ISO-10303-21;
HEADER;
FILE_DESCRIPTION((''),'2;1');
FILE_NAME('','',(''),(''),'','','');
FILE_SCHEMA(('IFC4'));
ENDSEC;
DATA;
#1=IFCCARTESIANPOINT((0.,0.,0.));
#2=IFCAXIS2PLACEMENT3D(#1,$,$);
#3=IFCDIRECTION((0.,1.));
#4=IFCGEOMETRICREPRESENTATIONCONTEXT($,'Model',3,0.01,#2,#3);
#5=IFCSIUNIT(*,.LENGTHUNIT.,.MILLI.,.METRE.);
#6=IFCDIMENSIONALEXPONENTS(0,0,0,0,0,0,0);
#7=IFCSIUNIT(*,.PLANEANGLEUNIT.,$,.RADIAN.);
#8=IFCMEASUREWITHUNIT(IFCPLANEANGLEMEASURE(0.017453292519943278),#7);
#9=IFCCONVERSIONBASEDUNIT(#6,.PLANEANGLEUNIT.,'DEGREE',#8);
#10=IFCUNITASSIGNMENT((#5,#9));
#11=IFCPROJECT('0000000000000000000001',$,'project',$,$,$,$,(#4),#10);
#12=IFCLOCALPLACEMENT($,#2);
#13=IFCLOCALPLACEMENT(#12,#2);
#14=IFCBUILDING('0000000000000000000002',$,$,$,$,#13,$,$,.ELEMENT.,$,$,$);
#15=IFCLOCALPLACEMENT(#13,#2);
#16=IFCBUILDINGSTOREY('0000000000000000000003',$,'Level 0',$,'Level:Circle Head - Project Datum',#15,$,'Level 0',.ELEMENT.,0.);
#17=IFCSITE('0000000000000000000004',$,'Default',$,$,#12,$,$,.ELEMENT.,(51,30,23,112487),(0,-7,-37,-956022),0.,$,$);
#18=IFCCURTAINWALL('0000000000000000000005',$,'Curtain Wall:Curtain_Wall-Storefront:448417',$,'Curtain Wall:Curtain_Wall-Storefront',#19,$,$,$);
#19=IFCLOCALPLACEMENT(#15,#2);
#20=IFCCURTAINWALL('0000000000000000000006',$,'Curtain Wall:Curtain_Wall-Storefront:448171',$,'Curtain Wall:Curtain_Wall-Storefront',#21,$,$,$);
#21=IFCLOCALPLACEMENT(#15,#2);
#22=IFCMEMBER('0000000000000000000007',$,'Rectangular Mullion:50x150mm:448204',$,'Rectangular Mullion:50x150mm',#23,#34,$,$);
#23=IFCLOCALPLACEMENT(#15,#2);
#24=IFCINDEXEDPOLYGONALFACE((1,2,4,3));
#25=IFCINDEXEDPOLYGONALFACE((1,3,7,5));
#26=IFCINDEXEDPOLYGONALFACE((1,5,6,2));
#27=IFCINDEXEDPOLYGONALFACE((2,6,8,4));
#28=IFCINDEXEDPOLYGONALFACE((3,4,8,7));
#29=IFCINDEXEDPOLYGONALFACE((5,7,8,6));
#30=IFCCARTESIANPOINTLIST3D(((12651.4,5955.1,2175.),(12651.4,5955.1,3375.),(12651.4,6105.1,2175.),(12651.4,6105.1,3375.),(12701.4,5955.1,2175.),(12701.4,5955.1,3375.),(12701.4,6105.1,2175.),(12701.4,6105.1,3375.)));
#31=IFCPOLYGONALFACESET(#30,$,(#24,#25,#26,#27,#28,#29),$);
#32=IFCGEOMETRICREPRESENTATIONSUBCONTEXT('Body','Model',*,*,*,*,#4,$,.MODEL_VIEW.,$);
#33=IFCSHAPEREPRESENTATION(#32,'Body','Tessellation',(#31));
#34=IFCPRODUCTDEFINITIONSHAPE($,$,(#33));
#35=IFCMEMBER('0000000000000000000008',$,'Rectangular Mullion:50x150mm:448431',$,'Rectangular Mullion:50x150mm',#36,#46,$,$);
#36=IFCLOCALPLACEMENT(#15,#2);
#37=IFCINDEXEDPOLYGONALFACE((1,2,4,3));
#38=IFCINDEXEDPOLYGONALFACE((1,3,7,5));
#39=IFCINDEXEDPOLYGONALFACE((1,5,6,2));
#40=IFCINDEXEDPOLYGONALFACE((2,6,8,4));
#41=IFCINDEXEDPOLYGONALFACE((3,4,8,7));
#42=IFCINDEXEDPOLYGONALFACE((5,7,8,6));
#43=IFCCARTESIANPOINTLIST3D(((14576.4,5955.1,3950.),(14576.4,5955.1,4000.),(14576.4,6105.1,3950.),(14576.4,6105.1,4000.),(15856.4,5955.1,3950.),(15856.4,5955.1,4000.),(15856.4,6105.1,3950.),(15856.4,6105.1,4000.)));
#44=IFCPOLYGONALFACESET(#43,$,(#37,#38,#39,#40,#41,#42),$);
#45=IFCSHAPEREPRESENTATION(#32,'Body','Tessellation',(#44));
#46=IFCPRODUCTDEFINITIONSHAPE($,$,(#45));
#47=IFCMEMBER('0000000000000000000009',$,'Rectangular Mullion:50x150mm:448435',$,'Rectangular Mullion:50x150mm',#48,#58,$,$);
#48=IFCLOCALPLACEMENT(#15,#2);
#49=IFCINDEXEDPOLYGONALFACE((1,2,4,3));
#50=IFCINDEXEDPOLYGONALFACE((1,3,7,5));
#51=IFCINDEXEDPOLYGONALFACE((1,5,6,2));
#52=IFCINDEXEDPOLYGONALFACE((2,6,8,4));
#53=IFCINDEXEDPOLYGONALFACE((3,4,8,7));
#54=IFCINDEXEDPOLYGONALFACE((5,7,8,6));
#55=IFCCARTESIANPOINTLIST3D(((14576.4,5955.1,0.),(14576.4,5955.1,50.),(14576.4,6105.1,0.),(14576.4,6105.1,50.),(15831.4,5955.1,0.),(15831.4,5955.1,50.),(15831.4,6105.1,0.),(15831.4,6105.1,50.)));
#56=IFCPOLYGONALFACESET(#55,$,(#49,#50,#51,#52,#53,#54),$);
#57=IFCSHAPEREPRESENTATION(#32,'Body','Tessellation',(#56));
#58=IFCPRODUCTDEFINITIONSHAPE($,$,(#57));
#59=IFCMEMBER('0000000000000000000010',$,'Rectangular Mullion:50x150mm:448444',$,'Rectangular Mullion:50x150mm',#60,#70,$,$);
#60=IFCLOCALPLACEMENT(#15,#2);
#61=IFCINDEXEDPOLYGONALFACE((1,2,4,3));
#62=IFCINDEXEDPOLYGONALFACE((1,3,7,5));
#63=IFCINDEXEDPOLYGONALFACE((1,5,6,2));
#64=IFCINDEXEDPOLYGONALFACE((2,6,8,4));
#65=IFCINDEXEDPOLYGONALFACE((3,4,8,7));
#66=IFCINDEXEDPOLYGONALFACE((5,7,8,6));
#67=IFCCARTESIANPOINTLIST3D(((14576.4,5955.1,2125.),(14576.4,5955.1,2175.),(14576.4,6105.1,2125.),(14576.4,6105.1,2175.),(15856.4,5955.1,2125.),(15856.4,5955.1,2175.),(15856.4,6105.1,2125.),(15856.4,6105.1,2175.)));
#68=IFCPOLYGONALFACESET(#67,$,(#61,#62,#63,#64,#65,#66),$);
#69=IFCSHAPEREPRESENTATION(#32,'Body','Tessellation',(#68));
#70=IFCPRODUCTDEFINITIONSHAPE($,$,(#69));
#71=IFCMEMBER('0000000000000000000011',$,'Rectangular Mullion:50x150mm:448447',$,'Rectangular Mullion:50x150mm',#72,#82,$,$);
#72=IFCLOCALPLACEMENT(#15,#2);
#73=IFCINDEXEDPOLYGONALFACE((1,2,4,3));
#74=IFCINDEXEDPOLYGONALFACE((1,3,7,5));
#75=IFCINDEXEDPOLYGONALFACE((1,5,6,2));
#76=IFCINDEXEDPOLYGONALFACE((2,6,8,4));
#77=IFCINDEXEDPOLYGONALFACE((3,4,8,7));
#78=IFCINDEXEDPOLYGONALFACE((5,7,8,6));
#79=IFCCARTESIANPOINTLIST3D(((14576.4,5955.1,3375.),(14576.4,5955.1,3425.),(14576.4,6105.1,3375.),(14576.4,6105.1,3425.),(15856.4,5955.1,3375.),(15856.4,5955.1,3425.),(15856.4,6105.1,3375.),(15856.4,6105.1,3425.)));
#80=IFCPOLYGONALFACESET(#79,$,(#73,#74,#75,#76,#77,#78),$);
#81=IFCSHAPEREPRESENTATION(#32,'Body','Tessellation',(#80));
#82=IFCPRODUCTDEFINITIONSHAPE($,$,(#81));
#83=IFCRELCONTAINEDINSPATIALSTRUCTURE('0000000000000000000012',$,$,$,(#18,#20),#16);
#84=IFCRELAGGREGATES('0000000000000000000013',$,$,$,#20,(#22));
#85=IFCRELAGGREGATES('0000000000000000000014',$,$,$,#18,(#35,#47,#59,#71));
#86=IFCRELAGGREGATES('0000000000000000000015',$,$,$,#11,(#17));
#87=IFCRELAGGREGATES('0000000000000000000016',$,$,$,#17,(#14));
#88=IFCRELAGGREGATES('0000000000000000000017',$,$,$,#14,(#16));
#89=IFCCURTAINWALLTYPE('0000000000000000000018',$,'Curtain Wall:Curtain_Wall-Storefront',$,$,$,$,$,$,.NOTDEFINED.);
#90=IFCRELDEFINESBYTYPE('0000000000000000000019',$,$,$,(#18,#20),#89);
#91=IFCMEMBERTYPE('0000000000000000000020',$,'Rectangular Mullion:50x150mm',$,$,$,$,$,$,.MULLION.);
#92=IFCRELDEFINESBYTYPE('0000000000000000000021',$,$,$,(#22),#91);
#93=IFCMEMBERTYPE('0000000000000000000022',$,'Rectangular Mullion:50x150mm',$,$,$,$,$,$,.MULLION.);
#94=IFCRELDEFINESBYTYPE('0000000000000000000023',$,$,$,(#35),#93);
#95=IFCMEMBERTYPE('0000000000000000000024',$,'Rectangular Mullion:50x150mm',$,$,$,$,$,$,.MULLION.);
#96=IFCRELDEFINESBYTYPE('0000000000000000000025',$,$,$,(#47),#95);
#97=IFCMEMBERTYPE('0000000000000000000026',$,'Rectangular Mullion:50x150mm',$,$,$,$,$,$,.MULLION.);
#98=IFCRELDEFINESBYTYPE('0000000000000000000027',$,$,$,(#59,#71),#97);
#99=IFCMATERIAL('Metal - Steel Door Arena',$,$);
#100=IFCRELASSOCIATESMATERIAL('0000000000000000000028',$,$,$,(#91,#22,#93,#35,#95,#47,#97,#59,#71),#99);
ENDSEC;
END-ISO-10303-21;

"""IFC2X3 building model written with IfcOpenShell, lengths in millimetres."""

from ifc_helpers import new_model, entity, si_unit, converted_unit, direction, frame, origin, origin_2d_with_axis, place, context, subcontext, project, spatial, rectangle, extrude, source, transform, mapped, material, type_object, type_shapes, element, aggregate, save


model = new_model("IFC2X3")

# Units and contexts
model_context = context("Model", 3, precision=0.01, world=origin(), true_north=direction((0.0, 1.0)))
body_context = subcontext(model_context, "Body", "Model", "MODEL_VIEW")
ifc_project = project(units=[si_unit("LENGTHUNIT", "METRE", prefix="MILLI"), converted_unit("PLANEANGLEUNIT", "DEGREE", entity("IfcPlaneAngleMeasure", 0.017453292519943278), si_unit("PLANEANGLEUNIT", "RADIAN"), dimensions=[0, 0, 0, 0, 0, 0, 0])], contexts=[model_context])

# Site, building, storey
site_placement = place(None, origin())
site = spatial("IfcSite", under=ifc_project, at=site_placement, Name="Default", CompositionType="ELEMENT", RefLatitude=(51, 30, 23, 112487), RefLongitude=(0, -7, -37, -956022), RefElevation=0.0)
building_placement = place(site_placement, origin())
building = spatial("IfcBuilding", under=site, at=building_placement, CompositionType="ELEMENT")
storey_placement = place(building_placement, origin())
storey = spatial("IfcBuildingStorey", under=building, at=storey_placement, Name="Level 0", ObjectType="Level:Circle Head - Project Datum", LongName="Level 0", CompositionType="ELEMENT", Elevation=0.0)

# Curtain walls
curtain_wall_type = type_object("IfcCurtainWallType", Name="Curtain Wall:Curtain_Wall-Storefront", PredefinedType="NOTDEFINED")
curtain_wall_1_placement = place(storey_placement, origin())
curtain_wall_1 = element("IfcCurtainWall", 1, at=curtain_wall_1_placement, inside=storey, type_object=curtain_wall_type, Name="Curtain Wall:Curtain_Wall-Storefront:448417", ObjectType="Curtain Wall:Curtain_Wall-Storefront")
ifc_material_1 = material(Name="Metal - Steel Door Arena")
curtain_wall_2_placement = place(storey_placement, origin())
curtain_wall_2 = element("IfcCurtainWall", 2, at=curtain_wall_2_placement, inside=storey, type_object=curtain_wall_type, Name="Curtain Wall:Curtain_Wall-Storefront:448171", ObjectType="Curtain Wall:Curtain_Wall-Storefront")

# Members
member_type_1 = type_object("IfcMemberType", Name="Rectangular Mullion:50x150mm", PredefinedType="MULLION", material=ifc_material_1)
shared_shape_1 = source(origin(), body_context, "Body", "SweptSolid", [
    extrude(rectangle(XDim=50.0, YDim=150.0, at=origin_2d_with_axis()), frame((0.0, 0.0, -1200.0), z_axis=(0.0, 0.0, 1.0), x_axis=(-1.0, 0.0, 0.0)), (0.0, 0.0, 1.0), 1200.0),
])
type_shapes(member_type_1, [shared_shape_1])
member_1_placement = place(curtain_wall_2_placement, frame((12676.4, 6030.1, 2175.0), z_axis=(0.0, 0.0, -1.0), x_axis=(-1.0, 0.0, 0.0)))
member_1 = element("IfcMember", 3, at=member_1_placement, type_object=member_type_1, material=ifc_material_1, Name="Rectangular Mullion:50x150mm:448204", ObjectType="Rectangular Mullion:50x150mm", context=body_context, shape_type="MappedRepresentation", body=[
    mapped(shared_shape_1, transform((0.0, 0.0, 0.0), scale=1.0)),
])
member_type_2 = type_object("IfcMemberType", Name="Rectangular Mullion:50x150mm", PredefinedType="MULLION", material=ifc_material_1)
shared_shape_2 = source(origin(), body_context, "Body", "SweptSolid", [
    extrude(rectangle(XDim=50.0, YDim=150.0, at=origin_2d_with_axis()), frame((-25.0, 0.0, -1280.0), z_axis=(0.0, 0.0, 1.0), x_axis=(-1.0, 0.0, 0.0)), (0.0, 0.0, 1.0), 1280.0),
])
type_shapes(member_type_2, [shared_shape_2])
member_2_placement = place(curtain_wall_1_placement, frame((14576.4, 6030.1, 4000.0), z_axis=(-1.0, 0.0, 0.0), x_axis=(0.0, 0.0, 1.0)))
member_2 = element("IfcMember", 4, at=member_2_placement, type_object=member_type_2, material=ifc_material_1, Name="Rectangular Mullion:50x150mm:448431", ObjectType="Rectangular Mullion:50x150mm", context=body_context, shape_type="MappedRepresentation", body=[
    mapped(shared_shape_2, transform((0.0, 0.0, 0.0), scale=1.0)),
])
member_type_3 = type_object("IfcMemberType", Name="Rectangular Mullion:50x150mm", PredefinedType="MULLION", material=ifc_material_1)
shared_shape_3 = source(origin(), body_context, "Body", "SweptSolid", [
    extrude(rectangle(XDim=50.0, YDim=150.0, at=origin_2d_with_axis()), frame((-25.0, 0.0, -1255.0), z_axis=(0.0, 0.0, 1.0), x_axis=(-1.0, 0.0, 0.0)), (0.0, 0.0, 1.0), 1255.0),
])
type_shapes(member_type_3, [shared_shape_3])
member_3_placement = place(curtain_wall_1_placement, frame((15831.4, 6030.1, 0.0), z_axis=(1.0, 0.0, 0.0), x_axis=(0.0, 0.0, -1.0)))
member_3 = element("IfcMember", 5, at=member_3_placement, type_object=member_type_3, material=ifc_material_1, Name="Rectangular Mullion:50x150mm:448435", ObjectType="Rectangular Mullion:50x150mm", context=body_context, shape_type="MappedRepresentation", body=[
    mapped(shared_shape_3, transform((0.0, 0.0, 0.0), scale=1.0)),
])
member_type_4 = type_object("IfcMemberType", Name="Rectangular Mullion:50x150mm", PredefinedType="MULLION", material=ifc_material_1)
shared_shape_4 = source(origin(), body_context, "Body", "SweptSolid", [
    extrude(rectangle(XDim=50.0, YDim=150.0, at=origin_2d_with_axis()), frame((0.0, 0.0, -1280.0), z_axis=(0.0, 0.0, 1.0), x_axis=(-1.0, 0.0, 0.0)), (0.0, 0.0, 1.0), 1280.0),
])
type_shapes(member_type_4, [shared_shape_4])
member_4_placement = place(curtain_wall_1_placement, frame((14576.4, 6030.1, 2150.0), z_axis=(-1.0, 0.0, 0.0), x_axis=(0.0, 0.0, 1.0)))
member_4 = element("IfcMember", 6, at=member_4_placement, type_object=member_type_4, material=ifc_material_1, Name="Rectangular Mullion:50x150mm:448444", ObjectType="Rectangular Mullion:50x150mm", context=body_context, shape_type="MappedRepresentation", body=[
    mapped(shared_shape_4, transform((0.0, 0.0, 0.0), scale=1.0)),
])
member_5_placement = place(curtain_wall_1_placement, frame((14576.4, 6030.1, 3400.0), z_axis=(-1.0, 0.0, 0.0), x_axis=(0.0, 0.0, 1.0)))
member_5 = element("IfcMember", 7, at=member_5_placement, type_object=member_type_4, material=ifc_material_1, Name="Rectangular Mullion:50x150mm:448447", ObjectType="Rectangular Mullion:50x150mm", context=body_context, shape_type="MappedRepresentation", body=[
    mapped(shared_shape_4, transform((0.0, 0.0, 0.0), scale=1.0)),
])

aggregate(curtain_wall_2, [member_1])
aggregate(curtain_wall_1, [member_2, member_3, member_4, member_5])

save(model, "model.ifc")
